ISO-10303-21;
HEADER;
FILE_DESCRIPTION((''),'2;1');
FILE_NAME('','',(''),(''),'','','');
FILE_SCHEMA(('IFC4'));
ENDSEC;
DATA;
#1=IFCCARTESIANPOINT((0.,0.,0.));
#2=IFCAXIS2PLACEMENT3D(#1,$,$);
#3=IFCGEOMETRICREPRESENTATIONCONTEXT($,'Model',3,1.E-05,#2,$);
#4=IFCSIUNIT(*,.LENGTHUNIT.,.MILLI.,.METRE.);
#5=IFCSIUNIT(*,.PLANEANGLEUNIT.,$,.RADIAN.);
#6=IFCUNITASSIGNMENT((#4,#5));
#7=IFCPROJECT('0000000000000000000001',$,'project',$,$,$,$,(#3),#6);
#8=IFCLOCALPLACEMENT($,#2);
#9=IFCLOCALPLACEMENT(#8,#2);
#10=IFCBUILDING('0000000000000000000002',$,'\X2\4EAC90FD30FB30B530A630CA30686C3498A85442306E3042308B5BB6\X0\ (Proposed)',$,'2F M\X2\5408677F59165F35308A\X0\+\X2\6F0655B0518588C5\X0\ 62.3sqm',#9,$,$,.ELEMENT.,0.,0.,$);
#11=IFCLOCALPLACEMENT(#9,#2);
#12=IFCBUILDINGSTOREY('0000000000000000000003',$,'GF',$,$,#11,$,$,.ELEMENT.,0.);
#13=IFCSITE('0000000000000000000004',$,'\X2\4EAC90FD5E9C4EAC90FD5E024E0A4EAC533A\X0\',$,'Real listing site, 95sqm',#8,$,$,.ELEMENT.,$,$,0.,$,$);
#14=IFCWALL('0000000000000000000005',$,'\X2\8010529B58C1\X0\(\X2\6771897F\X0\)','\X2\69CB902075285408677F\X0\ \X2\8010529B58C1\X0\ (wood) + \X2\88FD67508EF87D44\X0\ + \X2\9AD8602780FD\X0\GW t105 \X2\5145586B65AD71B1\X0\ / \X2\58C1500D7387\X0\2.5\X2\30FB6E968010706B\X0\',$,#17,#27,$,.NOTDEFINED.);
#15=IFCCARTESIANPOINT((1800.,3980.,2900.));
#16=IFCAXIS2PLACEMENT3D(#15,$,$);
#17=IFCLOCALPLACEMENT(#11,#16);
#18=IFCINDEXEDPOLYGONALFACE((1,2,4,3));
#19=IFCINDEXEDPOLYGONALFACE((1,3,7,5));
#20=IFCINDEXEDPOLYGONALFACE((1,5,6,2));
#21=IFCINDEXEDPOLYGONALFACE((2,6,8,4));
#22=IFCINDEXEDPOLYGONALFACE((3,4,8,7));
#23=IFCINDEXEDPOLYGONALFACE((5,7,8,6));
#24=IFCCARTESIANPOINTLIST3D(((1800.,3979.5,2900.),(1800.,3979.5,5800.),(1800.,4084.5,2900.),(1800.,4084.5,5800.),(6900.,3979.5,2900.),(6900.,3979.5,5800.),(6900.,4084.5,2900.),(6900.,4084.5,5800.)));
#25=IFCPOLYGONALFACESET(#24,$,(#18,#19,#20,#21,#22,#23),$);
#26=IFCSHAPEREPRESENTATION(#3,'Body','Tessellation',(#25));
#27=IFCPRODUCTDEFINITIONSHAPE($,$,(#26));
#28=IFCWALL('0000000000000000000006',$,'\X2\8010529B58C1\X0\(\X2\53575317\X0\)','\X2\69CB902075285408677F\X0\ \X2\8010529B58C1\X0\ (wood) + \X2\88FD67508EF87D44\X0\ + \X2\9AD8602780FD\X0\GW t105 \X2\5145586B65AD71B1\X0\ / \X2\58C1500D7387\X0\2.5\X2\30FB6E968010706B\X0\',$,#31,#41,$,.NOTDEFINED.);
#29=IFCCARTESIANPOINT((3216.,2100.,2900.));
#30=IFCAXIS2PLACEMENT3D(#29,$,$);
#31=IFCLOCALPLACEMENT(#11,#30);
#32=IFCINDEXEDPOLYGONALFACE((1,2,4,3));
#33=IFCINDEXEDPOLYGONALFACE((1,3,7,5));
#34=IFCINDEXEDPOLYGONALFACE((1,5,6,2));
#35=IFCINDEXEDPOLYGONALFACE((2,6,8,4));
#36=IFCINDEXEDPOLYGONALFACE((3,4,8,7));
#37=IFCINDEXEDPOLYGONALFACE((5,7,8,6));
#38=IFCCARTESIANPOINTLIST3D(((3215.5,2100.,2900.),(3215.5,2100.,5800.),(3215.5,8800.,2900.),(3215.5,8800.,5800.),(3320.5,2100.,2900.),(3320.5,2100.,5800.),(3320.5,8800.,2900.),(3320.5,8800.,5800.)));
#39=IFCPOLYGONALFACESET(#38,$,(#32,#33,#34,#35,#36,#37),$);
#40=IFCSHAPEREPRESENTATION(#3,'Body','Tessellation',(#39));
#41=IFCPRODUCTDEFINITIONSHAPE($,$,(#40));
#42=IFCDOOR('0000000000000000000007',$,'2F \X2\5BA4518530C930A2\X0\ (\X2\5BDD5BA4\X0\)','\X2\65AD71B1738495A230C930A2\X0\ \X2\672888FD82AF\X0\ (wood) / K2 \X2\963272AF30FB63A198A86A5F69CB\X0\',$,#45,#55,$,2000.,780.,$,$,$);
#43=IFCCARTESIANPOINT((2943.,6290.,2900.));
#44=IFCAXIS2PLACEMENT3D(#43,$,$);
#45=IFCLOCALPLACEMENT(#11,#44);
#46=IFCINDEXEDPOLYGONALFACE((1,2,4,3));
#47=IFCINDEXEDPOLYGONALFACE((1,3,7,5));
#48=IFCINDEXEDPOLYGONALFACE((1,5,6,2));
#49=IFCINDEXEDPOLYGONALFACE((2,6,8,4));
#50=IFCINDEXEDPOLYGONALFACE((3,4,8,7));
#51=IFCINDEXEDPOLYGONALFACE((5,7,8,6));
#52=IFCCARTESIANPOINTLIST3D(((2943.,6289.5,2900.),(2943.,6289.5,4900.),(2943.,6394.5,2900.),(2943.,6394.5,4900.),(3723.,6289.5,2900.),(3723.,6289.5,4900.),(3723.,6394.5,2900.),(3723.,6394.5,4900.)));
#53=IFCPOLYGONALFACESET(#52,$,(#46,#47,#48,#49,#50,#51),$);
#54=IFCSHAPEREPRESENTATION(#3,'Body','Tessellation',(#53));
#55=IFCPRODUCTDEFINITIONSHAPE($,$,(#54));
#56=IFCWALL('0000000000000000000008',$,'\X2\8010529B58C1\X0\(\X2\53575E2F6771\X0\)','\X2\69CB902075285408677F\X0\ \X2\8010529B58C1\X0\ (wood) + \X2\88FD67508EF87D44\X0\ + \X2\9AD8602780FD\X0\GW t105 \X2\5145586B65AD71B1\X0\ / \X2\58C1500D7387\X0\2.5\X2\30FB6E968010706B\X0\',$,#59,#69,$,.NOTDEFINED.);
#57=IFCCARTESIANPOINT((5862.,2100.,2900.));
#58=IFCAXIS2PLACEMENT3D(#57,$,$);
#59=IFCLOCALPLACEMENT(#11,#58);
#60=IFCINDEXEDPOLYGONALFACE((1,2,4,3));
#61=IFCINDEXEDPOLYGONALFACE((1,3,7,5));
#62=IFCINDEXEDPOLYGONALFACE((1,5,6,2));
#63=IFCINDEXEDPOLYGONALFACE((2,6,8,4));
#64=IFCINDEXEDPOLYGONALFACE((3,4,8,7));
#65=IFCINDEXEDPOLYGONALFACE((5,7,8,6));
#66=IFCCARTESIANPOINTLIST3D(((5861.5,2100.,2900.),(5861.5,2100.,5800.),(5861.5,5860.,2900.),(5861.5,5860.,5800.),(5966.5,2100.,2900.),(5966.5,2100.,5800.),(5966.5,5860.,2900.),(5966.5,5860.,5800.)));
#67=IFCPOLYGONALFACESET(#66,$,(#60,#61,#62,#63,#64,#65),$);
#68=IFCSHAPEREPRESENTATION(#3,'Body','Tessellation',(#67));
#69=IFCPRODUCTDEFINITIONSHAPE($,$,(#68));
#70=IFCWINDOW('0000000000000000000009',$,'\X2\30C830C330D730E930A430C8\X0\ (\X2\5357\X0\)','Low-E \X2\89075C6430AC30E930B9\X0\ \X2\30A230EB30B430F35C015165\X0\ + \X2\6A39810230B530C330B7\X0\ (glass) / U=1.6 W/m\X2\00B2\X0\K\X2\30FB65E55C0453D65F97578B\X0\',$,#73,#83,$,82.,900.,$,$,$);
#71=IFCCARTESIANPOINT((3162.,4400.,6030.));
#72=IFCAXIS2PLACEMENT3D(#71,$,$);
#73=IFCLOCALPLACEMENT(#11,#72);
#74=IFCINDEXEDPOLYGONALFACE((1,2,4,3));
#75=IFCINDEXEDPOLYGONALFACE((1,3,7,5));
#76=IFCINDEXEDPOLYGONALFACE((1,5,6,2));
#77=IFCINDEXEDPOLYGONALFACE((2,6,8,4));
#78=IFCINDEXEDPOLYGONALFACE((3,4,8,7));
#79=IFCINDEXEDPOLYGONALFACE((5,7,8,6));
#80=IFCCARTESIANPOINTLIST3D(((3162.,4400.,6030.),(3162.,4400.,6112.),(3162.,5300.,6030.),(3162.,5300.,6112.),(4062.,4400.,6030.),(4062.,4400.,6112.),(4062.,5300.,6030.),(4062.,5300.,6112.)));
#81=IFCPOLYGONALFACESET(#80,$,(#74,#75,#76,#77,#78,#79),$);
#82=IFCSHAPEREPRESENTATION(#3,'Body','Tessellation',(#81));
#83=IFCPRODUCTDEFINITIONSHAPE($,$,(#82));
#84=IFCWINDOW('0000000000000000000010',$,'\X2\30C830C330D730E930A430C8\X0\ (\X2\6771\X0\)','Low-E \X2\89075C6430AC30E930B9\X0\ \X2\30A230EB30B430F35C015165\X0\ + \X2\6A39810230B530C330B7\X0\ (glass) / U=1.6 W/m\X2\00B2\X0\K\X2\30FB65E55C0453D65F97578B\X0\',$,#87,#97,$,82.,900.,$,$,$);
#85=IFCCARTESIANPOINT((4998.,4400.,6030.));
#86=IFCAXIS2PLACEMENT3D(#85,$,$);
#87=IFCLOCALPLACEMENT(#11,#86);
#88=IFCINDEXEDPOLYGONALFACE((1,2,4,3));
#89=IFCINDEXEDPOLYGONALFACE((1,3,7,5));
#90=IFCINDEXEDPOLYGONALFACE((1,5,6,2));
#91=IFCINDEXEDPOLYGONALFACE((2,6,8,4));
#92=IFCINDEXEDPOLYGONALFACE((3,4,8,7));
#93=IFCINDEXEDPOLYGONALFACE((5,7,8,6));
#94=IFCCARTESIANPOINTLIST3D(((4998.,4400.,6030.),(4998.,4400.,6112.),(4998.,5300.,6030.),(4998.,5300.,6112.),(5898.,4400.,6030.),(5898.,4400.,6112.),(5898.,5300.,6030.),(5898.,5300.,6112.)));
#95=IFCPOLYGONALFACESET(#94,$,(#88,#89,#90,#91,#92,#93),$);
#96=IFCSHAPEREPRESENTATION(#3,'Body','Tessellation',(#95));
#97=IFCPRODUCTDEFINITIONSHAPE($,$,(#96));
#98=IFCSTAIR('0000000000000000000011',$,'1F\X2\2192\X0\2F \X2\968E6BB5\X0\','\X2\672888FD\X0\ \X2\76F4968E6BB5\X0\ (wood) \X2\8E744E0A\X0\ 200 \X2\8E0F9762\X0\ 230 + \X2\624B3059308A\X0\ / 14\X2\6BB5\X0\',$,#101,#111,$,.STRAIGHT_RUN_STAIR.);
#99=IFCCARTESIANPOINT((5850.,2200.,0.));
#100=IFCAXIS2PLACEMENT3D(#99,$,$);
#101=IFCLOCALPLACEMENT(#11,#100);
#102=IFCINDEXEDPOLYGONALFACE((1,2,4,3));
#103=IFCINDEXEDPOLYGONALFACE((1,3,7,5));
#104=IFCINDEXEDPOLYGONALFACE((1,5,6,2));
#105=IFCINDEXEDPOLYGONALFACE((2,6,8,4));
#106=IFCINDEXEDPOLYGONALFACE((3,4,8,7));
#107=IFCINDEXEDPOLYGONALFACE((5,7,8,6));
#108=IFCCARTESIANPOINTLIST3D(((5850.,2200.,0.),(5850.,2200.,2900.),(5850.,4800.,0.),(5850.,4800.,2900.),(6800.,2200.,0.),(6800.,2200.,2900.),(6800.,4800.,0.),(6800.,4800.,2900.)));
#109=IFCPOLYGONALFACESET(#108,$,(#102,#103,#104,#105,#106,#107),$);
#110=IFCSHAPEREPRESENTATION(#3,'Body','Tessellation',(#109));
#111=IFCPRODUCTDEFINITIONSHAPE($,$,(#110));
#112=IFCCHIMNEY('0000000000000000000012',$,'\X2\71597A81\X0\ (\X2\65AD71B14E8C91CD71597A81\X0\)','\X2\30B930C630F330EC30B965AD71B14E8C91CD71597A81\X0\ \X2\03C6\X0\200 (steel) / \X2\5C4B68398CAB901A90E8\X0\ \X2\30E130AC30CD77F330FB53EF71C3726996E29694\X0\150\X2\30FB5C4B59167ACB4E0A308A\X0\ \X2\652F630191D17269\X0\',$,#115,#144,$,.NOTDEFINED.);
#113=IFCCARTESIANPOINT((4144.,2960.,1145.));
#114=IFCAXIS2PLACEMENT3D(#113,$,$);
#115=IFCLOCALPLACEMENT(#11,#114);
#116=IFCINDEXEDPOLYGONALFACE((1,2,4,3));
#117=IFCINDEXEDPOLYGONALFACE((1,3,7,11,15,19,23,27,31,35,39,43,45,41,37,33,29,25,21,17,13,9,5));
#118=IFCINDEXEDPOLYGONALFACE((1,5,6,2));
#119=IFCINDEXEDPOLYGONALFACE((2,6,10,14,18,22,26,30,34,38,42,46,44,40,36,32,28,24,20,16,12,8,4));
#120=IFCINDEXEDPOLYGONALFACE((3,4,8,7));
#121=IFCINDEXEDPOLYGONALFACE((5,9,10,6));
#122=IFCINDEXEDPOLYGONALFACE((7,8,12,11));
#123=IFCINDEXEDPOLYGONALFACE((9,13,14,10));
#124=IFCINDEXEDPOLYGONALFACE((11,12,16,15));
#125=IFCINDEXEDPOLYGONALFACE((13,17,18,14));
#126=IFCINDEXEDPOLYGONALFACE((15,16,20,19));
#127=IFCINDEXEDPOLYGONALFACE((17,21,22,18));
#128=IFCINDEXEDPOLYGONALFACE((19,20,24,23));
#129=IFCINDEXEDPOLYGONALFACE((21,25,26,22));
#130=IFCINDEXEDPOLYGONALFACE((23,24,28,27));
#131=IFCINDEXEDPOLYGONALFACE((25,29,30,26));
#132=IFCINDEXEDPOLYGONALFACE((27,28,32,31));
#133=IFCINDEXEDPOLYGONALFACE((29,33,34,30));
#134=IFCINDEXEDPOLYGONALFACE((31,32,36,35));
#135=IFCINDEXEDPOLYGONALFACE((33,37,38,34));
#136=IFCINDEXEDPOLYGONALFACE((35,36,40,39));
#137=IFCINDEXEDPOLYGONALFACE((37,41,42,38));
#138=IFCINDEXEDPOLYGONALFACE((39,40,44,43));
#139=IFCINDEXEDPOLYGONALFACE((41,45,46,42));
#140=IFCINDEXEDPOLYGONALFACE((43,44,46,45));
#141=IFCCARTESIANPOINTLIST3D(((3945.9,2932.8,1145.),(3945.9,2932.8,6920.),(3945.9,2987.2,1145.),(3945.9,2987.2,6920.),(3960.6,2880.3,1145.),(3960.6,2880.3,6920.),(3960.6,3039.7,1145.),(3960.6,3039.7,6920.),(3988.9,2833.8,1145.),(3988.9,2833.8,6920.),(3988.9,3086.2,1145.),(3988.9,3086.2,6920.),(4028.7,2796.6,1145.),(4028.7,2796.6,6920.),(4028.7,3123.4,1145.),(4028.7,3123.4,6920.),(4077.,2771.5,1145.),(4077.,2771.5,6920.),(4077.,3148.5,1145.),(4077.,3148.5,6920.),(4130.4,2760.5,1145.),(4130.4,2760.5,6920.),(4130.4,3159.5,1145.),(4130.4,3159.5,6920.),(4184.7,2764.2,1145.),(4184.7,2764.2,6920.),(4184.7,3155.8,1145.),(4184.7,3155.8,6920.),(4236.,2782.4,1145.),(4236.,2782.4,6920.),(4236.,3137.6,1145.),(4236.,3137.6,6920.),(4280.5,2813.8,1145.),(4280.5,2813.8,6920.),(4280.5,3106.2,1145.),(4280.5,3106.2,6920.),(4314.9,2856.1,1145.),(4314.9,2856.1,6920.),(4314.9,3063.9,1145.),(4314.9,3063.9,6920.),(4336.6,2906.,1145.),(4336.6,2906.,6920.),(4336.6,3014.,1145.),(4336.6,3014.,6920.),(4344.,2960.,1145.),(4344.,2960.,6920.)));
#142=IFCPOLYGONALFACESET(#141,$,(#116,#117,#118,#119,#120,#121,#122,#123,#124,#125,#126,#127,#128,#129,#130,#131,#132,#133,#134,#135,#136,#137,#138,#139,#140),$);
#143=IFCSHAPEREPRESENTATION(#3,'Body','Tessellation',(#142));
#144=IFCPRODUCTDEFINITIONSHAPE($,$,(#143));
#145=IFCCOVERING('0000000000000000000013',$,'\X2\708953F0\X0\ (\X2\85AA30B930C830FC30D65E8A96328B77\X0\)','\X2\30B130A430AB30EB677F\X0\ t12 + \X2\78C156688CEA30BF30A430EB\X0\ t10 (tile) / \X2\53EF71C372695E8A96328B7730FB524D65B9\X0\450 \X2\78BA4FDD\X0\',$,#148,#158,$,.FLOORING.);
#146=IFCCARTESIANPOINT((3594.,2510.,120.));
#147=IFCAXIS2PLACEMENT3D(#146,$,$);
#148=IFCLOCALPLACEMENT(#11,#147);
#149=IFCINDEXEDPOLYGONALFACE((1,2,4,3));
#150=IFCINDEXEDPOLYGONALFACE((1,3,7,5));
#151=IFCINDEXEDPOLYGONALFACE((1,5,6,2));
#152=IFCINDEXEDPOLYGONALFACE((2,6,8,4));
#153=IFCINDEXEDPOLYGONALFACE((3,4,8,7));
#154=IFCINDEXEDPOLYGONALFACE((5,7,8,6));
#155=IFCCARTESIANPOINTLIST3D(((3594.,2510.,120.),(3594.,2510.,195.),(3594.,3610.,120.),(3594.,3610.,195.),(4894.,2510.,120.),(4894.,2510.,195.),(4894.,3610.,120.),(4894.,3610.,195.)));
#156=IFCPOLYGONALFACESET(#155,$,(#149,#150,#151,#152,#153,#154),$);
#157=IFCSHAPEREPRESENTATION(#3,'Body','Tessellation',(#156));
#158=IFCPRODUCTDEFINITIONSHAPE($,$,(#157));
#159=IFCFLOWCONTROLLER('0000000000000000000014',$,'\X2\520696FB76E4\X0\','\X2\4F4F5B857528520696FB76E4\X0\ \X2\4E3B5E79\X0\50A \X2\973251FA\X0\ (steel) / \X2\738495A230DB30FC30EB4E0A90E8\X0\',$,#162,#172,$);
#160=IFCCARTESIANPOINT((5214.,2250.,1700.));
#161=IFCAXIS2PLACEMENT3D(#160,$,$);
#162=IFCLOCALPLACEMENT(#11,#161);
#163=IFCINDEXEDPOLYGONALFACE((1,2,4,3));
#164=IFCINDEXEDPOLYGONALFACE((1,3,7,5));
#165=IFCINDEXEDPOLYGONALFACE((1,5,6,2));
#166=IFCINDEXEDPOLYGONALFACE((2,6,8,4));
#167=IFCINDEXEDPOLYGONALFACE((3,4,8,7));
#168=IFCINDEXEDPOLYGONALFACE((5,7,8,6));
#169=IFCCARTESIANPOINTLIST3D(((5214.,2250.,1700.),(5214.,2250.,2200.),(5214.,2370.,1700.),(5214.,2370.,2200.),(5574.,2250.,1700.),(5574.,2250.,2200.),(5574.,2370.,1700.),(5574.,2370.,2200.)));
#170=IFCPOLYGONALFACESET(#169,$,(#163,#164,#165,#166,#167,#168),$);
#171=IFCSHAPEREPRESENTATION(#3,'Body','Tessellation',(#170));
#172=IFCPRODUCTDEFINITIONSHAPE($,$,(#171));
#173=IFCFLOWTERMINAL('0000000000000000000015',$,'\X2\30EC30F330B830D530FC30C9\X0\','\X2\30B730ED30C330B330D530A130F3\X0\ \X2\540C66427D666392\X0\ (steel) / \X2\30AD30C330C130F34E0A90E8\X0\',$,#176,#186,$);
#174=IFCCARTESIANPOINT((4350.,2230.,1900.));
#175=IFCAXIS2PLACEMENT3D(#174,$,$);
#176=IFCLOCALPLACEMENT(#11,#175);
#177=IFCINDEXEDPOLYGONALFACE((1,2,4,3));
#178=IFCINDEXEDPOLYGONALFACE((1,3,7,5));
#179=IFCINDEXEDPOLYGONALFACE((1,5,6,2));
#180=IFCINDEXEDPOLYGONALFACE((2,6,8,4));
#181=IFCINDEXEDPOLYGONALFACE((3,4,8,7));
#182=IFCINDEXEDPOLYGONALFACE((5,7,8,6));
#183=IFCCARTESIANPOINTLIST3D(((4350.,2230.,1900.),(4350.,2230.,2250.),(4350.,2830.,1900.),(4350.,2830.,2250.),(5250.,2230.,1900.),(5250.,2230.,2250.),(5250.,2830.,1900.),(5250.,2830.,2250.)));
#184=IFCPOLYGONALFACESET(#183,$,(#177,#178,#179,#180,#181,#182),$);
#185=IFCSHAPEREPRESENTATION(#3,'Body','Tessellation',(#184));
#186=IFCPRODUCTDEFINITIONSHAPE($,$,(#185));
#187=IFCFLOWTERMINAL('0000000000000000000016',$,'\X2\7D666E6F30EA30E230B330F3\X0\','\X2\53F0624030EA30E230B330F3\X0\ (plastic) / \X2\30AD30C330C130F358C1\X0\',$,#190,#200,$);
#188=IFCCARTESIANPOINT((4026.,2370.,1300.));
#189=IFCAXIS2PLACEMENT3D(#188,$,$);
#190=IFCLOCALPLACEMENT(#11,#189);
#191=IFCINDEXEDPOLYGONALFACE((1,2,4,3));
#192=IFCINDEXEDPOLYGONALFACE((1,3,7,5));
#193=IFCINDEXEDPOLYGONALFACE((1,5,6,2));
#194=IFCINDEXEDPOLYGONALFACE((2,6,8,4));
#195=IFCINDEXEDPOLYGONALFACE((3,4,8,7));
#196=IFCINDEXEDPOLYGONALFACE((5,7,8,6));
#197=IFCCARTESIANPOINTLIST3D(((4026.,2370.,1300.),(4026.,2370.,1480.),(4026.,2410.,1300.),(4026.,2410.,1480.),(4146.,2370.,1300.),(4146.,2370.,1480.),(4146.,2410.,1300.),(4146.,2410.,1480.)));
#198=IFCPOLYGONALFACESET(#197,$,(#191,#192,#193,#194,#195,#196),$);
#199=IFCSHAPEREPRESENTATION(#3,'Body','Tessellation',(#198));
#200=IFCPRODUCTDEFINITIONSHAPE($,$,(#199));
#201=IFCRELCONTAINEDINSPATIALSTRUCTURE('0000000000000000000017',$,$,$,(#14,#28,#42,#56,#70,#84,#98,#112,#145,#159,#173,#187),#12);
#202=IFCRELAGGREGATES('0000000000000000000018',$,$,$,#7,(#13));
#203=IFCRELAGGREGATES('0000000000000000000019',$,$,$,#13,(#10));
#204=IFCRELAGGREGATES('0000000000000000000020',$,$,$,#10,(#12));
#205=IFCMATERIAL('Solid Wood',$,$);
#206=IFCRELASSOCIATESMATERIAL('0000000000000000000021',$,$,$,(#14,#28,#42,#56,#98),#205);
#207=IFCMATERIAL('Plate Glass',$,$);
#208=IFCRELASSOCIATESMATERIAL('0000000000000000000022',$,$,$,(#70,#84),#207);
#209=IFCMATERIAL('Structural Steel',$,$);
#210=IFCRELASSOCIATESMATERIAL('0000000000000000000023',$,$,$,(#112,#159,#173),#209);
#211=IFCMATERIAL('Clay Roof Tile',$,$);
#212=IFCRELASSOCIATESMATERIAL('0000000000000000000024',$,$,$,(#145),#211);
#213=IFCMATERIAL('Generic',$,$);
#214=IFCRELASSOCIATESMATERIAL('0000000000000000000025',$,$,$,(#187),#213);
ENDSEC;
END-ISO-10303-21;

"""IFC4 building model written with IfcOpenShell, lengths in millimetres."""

from ifc_helpers import new_model, si_unit, frame, frame_2d, origin, origin_2d, place, context, project, spatial, rectangle, circle, extrude, material, element, fill, save


model = new_model("IFC4")

# Units and contexts
model_context = context("Model", 3, precision=1e-05, world=origin())
ifc_project = project(units=[si_unit("LENGTHUNIT", "METRE", prefix="MILLI"), si_unit("PLANEANGLEUNIT", "RADIAN")], contexts=[model_context])

# Site, building, storey
site_placement = place(None, origin())
site = spatial("IfcSite", under=ifc_project, at=site_placement, Name="京都府京都市上京区", ObjectType="Real listing site, 95sqm", CompositionType="ELEMENT", RefElevation=0.0)
building_placement = place(site_placement, origin())
building = spatial("IfcBuilding", under=site, at=building_placement, Name="京都・サウナと水風呂のある家 (Proposed)", ObjectType="2F M合板外張り+漆喰内装 62.3sqm", CompositionType="ELEMENT", ElevationOfRefHeight=0.0, ElevationOfTerrain=0.0)
storey_placement = place(building_placement, origin())
storey = spatial("IfcBuildingStorey", under=building, at=storey_placement, Name="GF", CompositionType="ELEMENT", Elevation=0.0)

# Shared definitions
ifc_material_1 = material(Name="Solid Wood")

# Wall
wall_1_placement = place(storey_placement, frame((1800.0, 3980.0, 2900.0)))
element("IfcWall", 1, at=wall_1_placement, inside=storey, material=ifc_material_1, Name="耐力壁(東西)", Description="構造用合板 耐力壁 (wood) + 製材軸組 + 高性能GW t105 充填断熱 / 壁倍率2.5・準耐火", PredefinedType="NOTDEFINED", context=model_context, shape_type="SweptSolid", body=[
    extrude(rectangle(XDim=5100.0, YDim=105.0, at=frame_2d((2550.0, 52.0))), frame((1800.0, 3980.0, 2900.0)), (0.0, 0.0, 1.0), 2900.0),
])

# Wall, opening, door
wall_2_placement = place(storey_placement, frame((3216.0, 2100.0, 2900.0)))
wall_2 = element("IfcWall", 2, at=wall_2_placement, inside=storey, material=ifc_material_1, Name="耐力壁(南北)", Description="構造用合板 耐力壁 (wood) + 製材軸組 + 高性能GW t105 充填断熱 / 壁倍率2.5・準耐火", PredefinedType="NOTDEFINED", context=model_context, shape_type="SweptSolid", body=[
    extrude(rectangle(XDim=105.0, YDim=6700.0, at=frame_2d((52.0, 3350.0))), frame((3216.0, 2100.0, 2900.0)), (0.0, 0.0, 1.0), 2900.0),
])
opening_placement = place(storey_placement, frame((2943.0, 6290.0, 2900.0)))
opening = element("IfcOpeningElement", 3, at=opening_placement, cuts=wall_2, PredefinedType="NOTDEFINED", context=model_context, shape_type="SweptSolid", body=[
    extrude(rectangle(XDim=780.0, YDim=105.0, at=frame_2d((390.0, 52.0))), frame((2943.0, 6290.0, 2900.0)), (0.0, 0.0, 1.0), 2000.0),
])
door_placement = place(storey_placement, frame((2943.0, 6290.0, 2900.0)))
door = element("IfcDoor", 4, at=door_placement, inside=storey, material=ifc_material_1, Name="2F 室内ドア (寝室)", Description="断熱玄関ドア 木製芯 (wood) / K2 防犯・採風機構", OverallHeight=2000.0, OverallWidth=780.0, context=model_context, shape_type="SweptSolid", body=[
    extrude(rectangle(XDim=780.0, YDim=105.0, at=frame_2d((390.0, 52.0))), frame((2943.0, 6290.0, 2900.0)), (0.0, 0.0, 1.0), 2000.0),
])
fill(opening, door)

# Wall
wall_3_placement = place(storey_placement, frame((5862.0, 2100.0, 2900.0)))
element("IfcWall", 5, at=wall_3_placement, inside=storey, material=ifc_material_1, Name="耐力壁(南帯東)", Description="構造用合板 耐力壁 (wood) + 製材軸組 + 高性能GW t105 充填断熱 / 壁倍率2.5・準耐火", PredefinedType="NOTDEFINED", context=model_context, shape_type="SweptSolid", body=[
    extrude(rectangle(XDim=105.0, YDim=3760.0, at=frame_2d((52.0, 1880.0))), frame((5862.0, 2100.0, 2900.0)), (0.0, 0.0, 1.0), 2900.0),
])

# Windows
ifc_material_2 = material(Name="Plate Glass")
window_1_placement = place(storey_placement, frame((3162.0, 4400.0, 6030.0)))
element("IfcWindow", 6, at=window_1_placement, inside=storey, material=ifc_material_2, Name="トップライト (南)", Description="Low-E 複層ガラス アルゴン封入 + 樹脂サッシ (glass) / U=1.6 W/m²K・日射取得型", OverallHeight=82.0, OverallWidth=900.0, context=model_context, shape_type="SweptSolid", body=[
    extrude(rectangle(XDim=900.0, YDim=900.0, at=frame_2d((450.0, 450.0))), frame((3162.0, 4400.0, 6030.0)), (0.0, 0.0, 1.0), 82.0),
])
window_2_placement = place(storey_placement, frame((4998.0, 4400.0, 6030.0)))
element("IfcWindow", 7, at=window_2_placement, inside=storey, material=ifc_material_2, Name="トップライト (東)", Description="Low-E 複層ガラス アルゴン封入 + 樹脂サッシ (glass) / U=1.6 W/m²K・日射取得型", OverallHeight=82.0, OverallWidth=900.0, context=model_context, shape_type="SweptSolid", body=[
    extrude(rectangle(XDim=900.0, YDim=900.0, at=frame_2d((450.0, 450.0))), frame((4998.0, 4400.0, 6030.0)), (0.0, 0.0, 1.0), 82.0),
])

# Stair
stair_placement = place(storey_placement, frame((5850.0, 2200.0, 0.0)))
element("IfcStair", 8, at=stair_placement, inside=storey, material=ifc_material_1, Name="1F→2F 階段", Description="木製 直階段 (wood) 蹴上 200 踏面 230 + 手すり / 14段", PredefinedType="STRAIGHT_RUN_STAIR", context=model_context, shape_type="SweptSolid", body=[
    extrude(rectangle(XDim=950.0, YDim=2600.0, at=frame_2d((475.0, 1300.0))), frame((5850.0, 2200.0, 0.0)), (0.0, 0.0, 1.0), 2900.0),
])

# Chimney
ifc_material_3 = material(Name="Structural Steel")
chimney_placement = place(storey_placement, frame((4144.0, 2960.0, 1145.0)))
element("IfcChimney", 9, at=chimney_placement, inside=storey, material=ifc_material_3, Name="煙突 (断熱二重煙突)", Description="ステンレス断熱二重煙突 φ200 (steel) / 屋根貫通部 メガネ石・可燃物離隔150・屋外立上り 支持金物", PredefinedType="NOTDEFINED", context=model_context, shape_type="SweptSolid", body=[
    extrude(circle(Radius=200.0, at=origin_2d()), frame((4144.0, 2960.0, 1145.0)), (0.0, 0.0, 1.0), 5775.0),
])

# Covering
ifc_material_4 = material(Name="Clay Roof Tile")
covering_placement = place(storey_placement, frame((3594.0, 2510.0, 120.0)))
element("IfcCovering", 10, at=covering_placement, inside=storey, material=ifc_material_4, Name="炉台 (薪ストーブ床防護)", Description="ケイカル板 t12 + 磁器質タイル t10 (tile) / 可燃物床防護・前方450 確保", PredefinedType="FLOORING", context=model_context, shape_type="SweptSolid", body=[
    extrude(rectangle(XDim=1300.0, YDim=1100.0, at=frame_2d((650.0, 550.0))), frame((3594.0, 2510.0, 120.0)), (0.0, 0.0, 1.0), 75.0),
])

# Flow controller
flow_controller_placement = place(storey_placement, frame((5214.0, 2250.0, 1700.0)))
element("IfcFlowController", 11, at=flow_controller_placement, inside=storey, material=ifc_material_3, Name="分電盤", Description="住宅用分電盤 主幹50A 露出 (steel) / 玄関ホール上部", context=model_context, shape_type="SweptSolid", body=[
    extrude(rectangle(XDim=360.0, YDim=120.0, at=frame_2d((180.0, 60.0))), frame((5214.0, 2250.0, 1700.0)), (0.0, 0.0, 1.0), 500.0),
])

# Flow terminals
flow_terminal_1_placement = place(storey_placement, frame((4350.0, 2230.0, 1900.0)))
element("IfcFlowTerminal", 12, at=flow_terminal_1_placement, inside=storey, material=ifc_material_3, Name="レンジフード", Description="シロッコファン 同時給排 (steel) / キッチン上部", context=model_context, shape_type="SweptSolid", body=[
    extrude(rectangle(XDim=900.0, YDim=600.0, at=frame_2d((450.0, 300.0))), frame((4350.0, 2230.0, 1900.0)), (0.0, 0.0, 1.0), 350.0),
])
ifc_material_5 = material(Name="Generic")
flow_terminal_2_placement = place(storey_placement, frame((4026.0, 2370.0, 1300.0)))
element("IfcFlowTerminal", 13, at=flow_terminal_2_placement, inside=storey, material=ifc_material_5, Name="給湯リモコン", Description="台所リモコン (plastic) / キッチン壁", context=model_context, shape_type="SweptSolid", body=[
    extrude(rectangle(XDim=120.0, YDim=40.0, at=frame_2d((60.0, 20.0))), frame((4026.0, 2370.0, 1300.0)), (0.0, 0.0, 1.0), 180.0),
])

save(model, "model.ifc")
